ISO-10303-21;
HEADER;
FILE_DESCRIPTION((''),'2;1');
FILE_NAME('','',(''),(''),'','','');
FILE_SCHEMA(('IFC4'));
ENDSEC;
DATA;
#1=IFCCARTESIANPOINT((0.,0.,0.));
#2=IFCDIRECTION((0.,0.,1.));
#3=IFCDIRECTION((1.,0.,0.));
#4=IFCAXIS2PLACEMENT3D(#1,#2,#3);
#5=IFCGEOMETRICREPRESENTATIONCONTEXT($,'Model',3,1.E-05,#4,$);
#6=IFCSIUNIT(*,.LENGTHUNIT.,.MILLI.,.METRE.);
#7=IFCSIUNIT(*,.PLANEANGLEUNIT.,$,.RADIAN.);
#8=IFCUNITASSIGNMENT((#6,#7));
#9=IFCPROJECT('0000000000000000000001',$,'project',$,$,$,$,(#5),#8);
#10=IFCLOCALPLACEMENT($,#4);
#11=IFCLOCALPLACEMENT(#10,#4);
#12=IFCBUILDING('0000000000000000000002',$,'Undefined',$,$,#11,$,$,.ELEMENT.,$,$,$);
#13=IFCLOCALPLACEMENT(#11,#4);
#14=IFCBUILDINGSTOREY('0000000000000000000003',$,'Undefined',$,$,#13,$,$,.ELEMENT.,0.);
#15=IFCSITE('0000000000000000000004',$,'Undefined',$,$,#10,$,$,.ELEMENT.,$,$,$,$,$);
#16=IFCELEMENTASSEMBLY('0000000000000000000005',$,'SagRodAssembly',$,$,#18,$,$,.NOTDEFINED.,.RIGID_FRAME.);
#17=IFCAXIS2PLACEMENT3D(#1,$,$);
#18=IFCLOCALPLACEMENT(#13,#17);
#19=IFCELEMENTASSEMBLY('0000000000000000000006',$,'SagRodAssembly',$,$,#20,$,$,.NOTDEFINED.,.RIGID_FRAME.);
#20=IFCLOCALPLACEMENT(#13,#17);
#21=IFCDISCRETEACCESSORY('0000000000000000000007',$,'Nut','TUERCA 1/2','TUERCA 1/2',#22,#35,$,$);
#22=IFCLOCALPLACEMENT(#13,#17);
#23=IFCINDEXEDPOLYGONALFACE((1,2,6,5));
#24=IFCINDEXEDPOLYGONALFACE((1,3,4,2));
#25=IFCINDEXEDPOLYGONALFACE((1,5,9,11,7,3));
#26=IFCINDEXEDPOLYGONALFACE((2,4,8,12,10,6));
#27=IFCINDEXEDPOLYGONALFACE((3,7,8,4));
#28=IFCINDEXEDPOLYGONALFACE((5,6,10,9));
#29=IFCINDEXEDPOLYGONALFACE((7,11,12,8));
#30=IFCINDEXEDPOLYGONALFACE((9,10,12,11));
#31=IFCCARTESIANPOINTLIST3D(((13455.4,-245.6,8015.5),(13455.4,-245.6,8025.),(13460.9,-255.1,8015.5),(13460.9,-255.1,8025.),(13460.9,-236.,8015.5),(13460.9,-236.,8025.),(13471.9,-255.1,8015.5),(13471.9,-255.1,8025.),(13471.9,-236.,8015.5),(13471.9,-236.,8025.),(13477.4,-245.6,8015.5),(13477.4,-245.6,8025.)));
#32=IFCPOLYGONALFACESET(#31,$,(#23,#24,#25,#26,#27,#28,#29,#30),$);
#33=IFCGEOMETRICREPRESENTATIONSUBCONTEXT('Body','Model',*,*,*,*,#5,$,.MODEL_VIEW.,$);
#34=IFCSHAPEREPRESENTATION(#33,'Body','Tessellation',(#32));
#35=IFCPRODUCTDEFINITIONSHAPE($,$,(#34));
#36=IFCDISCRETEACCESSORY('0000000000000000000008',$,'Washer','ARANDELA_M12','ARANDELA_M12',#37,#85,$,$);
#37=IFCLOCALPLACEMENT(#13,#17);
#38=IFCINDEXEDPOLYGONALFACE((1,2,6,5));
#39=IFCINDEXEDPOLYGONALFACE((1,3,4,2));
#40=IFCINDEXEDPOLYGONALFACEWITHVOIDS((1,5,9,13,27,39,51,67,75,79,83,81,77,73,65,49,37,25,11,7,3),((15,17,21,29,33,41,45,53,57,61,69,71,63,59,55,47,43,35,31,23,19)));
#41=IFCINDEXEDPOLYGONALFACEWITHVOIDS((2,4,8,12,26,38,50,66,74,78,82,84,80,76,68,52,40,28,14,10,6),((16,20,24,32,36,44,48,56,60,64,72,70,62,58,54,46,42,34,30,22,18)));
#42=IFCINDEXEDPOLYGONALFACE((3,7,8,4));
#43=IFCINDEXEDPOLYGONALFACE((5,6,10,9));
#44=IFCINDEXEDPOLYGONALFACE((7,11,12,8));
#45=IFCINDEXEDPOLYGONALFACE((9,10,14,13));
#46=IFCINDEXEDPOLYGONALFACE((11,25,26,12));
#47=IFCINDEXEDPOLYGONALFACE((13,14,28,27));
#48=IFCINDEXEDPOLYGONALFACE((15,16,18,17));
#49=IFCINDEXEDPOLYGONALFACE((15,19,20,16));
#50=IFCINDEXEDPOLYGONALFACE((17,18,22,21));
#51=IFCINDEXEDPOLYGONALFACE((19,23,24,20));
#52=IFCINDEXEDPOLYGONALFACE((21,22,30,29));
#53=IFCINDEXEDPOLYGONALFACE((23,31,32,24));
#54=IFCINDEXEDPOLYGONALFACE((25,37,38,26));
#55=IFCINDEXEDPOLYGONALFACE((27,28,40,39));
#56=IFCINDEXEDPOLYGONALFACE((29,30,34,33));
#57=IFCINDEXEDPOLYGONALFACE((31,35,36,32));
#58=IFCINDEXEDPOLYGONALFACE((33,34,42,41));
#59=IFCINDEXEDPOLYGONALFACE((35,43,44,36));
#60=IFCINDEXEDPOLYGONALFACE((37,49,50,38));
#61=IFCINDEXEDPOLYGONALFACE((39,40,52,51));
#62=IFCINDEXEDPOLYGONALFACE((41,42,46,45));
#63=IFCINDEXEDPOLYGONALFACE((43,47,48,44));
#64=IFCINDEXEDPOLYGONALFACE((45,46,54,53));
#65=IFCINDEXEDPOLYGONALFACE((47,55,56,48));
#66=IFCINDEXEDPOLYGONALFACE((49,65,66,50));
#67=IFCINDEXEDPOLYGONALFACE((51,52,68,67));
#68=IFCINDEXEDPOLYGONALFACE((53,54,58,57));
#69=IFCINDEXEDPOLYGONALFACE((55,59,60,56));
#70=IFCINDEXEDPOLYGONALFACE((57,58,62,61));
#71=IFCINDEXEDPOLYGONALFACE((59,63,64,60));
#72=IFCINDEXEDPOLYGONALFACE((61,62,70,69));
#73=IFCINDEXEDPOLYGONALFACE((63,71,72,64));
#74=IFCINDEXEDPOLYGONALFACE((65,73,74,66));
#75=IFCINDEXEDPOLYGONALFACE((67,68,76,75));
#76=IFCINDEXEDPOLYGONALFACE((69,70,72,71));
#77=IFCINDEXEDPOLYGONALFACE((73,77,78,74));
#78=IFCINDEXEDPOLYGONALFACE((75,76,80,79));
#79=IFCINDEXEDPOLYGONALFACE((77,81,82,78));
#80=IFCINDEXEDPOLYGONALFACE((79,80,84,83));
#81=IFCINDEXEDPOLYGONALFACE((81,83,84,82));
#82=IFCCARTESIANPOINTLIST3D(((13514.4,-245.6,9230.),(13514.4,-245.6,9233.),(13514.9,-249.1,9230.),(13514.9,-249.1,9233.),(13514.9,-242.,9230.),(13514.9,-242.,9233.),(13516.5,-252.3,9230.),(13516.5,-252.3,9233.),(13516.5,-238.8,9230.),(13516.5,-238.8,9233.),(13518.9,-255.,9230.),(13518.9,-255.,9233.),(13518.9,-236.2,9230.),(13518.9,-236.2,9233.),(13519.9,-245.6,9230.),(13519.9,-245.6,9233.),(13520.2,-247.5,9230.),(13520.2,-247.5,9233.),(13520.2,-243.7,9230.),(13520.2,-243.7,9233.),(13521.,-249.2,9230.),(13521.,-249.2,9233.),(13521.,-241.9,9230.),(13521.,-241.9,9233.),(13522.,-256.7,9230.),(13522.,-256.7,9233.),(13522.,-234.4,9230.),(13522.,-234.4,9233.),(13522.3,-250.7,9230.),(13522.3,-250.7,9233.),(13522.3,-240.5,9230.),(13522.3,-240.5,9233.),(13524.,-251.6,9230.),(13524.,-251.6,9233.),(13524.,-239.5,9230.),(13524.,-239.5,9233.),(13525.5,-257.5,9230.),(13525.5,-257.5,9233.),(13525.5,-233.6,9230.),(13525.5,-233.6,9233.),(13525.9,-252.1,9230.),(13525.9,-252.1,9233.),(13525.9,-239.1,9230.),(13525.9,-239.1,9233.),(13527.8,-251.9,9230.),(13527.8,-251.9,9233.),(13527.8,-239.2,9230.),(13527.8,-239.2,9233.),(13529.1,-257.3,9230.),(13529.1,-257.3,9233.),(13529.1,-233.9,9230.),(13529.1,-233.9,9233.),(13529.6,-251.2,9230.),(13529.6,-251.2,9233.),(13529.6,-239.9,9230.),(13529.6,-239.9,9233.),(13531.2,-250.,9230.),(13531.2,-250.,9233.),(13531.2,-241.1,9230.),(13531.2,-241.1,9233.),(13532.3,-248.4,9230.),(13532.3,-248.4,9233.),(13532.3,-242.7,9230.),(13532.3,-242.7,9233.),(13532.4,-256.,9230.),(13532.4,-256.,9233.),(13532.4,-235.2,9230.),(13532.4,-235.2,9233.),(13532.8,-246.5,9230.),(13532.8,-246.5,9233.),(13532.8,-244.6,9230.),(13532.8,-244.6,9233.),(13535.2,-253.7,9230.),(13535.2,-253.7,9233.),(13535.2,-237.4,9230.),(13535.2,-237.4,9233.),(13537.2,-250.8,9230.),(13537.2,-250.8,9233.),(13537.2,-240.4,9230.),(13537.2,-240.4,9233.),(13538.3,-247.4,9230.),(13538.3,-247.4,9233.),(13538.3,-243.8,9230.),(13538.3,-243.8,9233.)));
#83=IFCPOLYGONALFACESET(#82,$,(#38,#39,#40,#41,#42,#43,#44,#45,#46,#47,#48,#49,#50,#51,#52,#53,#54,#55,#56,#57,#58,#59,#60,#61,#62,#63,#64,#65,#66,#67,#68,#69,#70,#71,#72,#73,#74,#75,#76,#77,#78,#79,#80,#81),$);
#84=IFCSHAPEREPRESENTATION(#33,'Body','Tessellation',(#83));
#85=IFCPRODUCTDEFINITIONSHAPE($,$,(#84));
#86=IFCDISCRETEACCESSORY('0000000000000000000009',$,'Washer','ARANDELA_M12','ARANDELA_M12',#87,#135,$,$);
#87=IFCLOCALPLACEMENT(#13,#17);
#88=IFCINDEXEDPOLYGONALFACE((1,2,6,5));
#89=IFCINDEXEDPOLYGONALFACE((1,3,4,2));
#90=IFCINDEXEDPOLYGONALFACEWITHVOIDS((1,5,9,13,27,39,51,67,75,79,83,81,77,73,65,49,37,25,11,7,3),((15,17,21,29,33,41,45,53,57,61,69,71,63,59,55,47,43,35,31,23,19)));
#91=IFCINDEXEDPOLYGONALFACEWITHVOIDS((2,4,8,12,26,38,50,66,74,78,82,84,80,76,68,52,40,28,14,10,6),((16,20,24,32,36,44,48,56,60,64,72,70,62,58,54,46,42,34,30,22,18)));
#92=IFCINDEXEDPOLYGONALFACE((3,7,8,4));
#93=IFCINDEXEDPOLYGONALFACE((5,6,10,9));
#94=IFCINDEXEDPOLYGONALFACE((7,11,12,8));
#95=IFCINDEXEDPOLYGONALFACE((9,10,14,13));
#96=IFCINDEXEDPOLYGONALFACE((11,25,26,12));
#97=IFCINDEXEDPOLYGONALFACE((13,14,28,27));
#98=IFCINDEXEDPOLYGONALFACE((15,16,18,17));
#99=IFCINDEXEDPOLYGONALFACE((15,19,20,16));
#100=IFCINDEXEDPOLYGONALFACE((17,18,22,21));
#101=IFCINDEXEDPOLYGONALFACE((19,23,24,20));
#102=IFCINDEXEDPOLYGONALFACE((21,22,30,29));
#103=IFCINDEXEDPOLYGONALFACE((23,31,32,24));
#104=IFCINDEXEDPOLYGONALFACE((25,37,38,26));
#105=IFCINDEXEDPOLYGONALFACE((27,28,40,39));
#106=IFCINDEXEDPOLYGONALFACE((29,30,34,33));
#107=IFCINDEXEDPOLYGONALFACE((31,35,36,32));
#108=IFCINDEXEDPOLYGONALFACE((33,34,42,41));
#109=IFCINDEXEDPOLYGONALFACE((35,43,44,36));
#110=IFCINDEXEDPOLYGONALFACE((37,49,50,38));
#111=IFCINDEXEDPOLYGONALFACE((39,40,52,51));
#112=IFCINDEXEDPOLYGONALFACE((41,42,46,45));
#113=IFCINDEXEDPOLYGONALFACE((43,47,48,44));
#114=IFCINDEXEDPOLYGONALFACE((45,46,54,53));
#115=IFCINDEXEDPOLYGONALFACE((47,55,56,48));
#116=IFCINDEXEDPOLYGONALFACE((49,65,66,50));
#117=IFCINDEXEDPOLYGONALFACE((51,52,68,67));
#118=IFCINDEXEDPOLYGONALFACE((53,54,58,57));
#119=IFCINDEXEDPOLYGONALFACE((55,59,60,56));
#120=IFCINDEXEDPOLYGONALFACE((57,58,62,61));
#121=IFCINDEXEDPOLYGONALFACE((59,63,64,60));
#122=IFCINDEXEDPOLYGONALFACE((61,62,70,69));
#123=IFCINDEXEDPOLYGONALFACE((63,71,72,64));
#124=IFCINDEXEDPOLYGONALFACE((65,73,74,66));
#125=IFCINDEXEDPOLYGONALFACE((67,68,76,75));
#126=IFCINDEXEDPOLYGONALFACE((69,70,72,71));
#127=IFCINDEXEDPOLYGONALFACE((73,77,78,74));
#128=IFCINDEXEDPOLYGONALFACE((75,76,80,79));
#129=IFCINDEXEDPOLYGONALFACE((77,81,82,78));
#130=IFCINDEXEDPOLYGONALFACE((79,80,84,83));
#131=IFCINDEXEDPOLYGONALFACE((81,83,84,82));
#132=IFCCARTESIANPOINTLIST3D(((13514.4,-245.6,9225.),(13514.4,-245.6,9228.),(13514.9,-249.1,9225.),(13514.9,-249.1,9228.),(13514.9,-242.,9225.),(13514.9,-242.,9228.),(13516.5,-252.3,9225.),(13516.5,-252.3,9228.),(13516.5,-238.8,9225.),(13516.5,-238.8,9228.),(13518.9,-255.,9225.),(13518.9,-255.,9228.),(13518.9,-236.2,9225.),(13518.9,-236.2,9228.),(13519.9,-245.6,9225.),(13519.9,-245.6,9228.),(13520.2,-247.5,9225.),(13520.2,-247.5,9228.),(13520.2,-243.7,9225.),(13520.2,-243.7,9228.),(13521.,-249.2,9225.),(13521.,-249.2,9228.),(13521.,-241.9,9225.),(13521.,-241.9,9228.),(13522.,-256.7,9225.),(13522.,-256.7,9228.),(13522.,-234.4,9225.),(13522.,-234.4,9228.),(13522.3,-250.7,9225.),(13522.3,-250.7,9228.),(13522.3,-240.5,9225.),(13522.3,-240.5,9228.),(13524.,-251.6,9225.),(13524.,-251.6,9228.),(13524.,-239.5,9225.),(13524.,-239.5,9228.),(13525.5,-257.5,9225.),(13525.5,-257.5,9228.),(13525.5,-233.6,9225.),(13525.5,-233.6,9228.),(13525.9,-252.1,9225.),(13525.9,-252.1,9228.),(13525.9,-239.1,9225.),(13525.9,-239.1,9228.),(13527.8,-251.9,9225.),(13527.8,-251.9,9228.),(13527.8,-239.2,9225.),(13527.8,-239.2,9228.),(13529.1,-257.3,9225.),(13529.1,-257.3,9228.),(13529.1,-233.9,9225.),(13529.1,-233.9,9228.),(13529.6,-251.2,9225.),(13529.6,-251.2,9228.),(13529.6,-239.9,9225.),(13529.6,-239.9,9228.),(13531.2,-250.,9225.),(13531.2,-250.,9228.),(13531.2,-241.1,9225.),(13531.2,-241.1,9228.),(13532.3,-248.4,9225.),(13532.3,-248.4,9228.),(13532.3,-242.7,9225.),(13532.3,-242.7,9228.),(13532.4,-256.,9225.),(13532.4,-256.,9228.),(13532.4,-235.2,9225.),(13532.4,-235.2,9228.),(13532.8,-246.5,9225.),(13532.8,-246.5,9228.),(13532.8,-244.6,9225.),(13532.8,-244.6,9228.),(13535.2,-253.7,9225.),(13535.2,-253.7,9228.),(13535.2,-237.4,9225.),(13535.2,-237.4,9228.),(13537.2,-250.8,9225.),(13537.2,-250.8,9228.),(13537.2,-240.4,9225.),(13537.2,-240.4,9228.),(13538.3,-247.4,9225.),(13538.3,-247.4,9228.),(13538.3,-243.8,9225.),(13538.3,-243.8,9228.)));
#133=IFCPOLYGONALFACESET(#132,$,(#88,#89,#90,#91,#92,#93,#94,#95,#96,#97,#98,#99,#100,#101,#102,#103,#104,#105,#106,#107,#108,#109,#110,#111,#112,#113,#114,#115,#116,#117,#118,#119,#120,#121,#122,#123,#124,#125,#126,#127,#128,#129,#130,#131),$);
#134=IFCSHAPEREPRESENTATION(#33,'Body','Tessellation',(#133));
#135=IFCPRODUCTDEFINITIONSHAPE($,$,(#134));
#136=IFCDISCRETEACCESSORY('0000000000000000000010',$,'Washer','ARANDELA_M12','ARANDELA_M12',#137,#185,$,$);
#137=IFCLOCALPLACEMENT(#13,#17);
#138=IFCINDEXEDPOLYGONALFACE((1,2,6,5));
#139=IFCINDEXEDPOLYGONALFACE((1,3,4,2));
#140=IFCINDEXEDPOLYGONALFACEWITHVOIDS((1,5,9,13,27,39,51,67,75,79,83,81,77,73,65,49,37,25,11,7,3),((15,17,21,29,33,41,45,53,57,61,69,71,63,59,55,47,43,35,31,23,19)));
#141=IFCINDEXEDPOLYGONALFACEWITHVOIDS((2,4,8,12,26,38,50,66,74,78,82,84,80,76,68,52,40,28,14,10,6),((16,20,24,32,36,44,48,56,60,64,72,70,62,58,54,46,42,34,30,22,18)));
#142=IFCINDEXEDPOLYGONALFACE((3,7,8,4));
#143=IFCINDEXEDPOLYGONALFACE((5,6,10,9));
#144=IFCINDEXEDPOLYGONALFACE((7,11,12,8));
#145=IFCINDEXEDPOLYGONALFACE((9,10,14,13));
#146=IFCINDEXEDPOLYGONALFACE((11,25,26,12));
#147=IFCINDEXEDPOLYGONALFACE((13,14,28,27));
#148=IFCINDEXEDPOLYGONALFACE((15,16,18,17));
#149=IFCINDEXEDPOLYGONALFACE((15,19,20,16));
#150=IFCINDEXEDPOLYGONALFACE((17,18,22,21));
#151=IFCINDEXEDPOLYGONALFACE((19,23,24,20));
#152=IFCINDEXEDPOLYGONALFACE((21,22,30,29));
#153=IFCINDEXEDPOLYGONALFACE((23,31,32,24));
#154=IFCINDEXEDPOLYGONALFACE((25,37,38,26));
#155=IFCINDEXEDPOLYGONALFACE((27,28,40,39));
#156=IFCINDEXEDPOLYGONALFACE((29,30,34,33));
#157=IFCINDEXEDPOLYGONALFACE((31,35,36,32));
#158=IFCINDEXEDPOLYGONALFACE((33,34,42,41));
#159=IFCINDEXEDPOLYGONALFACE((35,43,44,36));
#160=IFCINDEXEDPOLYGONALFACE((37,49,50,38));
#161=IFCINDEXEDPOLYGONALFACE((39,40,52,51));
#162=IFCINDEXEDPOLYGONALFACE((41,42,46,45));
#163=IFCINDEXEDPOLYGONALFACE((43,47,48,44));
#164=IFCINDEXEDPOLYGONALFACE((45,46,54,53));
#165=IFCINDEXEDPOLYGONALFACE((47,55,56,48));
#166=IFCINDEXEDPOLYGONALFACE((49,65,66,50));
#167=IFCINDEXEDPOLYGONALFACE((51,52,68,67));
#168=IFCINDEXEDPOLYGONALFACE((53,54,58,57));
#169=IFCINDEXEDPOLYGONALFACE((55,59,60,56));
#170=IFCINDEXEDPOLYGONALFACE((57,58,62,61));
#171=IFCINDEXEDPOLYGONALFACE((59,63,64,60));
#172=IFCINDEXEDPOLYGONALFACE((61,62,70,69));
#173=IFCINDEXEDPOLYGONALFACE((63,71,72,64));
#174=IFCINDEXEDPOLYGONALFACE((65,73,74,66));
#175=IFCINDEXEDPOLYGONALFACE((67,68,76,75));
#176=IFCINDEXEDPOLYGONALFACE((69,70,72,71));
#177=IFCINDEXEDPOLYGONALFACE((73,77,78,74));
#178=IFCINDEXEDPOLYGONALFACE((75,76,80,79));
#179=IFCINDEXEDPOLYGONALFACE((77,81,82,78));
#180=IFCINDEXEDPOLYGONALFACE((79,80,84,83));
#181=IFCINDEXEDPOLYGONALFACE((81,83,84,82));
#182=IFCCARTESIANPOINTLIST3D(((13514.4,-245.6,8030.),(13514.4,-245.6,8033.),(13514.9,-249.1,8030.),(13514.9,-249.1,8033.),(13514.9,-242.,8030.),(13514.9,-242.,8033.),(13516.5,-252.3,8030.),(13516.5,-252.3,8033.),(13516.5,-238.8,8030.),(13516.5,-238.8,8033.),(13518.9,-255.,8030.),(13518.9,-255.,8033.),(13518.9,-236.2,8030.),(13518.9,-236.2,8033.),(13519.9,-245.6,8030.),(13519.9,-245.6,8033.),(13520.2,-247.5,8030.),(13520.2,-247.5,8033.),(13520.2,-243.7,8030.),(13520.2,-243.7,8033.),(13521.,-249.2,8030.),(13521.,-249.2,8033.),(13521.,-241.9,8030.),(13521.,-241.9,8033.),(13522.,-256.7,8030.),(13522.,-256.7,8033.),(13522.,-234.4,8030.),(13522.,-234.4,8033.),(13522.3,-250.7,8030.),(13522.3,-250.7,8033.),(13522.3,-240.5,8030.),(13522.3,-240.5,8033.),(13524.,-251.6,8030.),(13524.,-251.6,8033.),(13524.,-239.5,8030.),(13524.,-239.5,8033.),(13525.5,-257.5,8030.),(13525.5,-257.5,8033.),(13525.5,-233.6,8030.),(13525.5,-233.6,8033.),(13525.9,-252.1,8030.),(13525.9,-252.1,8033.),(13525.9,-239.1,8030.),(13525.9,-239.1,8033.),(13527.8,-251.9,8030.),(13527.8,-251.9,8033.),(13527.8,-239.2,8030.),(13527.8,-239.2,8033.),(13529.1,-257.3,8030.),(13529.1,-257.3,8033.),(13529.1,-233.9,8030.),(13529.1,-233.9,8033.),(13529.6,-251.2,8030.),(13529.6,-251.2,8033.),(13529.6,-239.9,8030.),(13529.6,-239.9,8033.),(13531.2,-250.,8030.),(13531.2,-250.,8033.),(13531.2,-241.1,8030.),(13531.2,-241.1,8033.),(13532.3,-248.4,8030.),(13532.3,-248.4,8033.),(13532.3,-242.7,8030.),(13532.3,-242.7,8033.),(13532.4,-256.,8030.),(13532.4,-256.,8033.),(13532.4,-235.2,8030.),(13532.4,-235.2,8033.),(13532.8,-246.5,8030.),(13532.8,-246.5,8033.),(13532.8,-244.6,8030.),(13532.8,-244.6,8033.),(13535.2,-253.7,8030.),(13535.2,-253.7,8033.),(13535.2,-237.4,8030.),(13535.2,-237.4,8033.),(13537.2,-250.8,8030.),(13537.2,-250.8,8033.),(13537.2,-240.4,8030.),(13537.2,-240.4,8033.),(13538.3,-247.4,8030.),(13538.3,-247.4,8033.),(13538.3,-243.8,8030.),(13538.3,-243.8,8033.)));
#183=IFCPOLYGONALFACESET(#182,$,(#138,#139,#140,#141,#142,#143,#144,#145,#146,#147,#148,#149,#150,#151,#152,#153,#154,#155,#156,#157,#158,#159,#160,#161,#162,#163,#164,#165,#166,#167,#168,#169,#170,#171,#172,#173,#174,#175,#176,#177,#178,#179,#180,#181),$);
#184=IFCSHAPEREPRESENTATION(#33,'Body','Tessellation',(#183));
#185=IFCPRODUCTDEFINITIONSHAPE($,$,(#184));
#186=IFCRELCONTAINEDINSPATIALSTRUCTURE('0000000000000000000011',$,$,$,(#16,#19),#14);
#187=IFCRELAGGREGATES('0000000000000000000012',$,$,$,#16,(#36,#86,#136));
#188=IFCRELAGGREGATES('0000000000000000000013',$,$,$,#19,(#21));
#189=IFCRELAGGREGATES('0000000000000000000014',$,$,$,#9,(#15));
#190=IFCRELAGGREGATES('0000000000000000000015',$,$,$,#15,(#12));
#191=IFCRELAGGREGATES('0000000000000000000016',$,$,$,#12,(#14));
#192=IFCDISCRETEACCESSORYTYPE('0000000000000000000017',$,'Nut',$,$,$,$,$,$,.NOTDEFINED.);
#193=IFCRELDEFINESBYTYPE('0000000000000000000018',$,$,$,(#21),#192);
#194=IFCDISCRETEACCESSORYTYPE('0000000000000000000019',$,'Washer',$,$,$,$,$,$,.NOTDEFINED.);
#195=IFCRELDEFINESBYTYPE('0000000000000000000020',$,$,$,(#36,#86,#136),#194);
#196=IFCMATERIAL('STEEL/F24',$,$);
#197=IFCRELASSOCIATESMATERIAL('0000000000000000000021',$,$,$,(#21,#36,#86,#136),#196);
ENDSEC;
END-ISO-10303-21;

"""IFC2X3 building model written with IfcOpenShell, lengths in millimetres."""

from ifc_helpers import new_model, si_unit, frame, origin_with_axes, origin_2d_with_axis, place, context, subcontext, project, spatial, polyline, hollow_circle, outline, extrude, material, type_object, element, aggregate, save


model = new_model("IFC2X3")

# Units and contexts
model_context = context("Model", 3, precision=1e-05, world=origin_with_axes())
body_context = subcontext(model_context, "Body", "Model", "MODEL_VIEW")
ifc_project = project(units=[si_unit("LENGTHUNIT", "METRE", prefix="MILLI"), si_unit("PLANEANGLEUNIT", "RADIAN")], contexts=[model_context])

# Site, building, storey
site_placement = place(None, origin_with_axes())
site = spatial("IfcSite", under=ifc_project, at=site_placement, Name="Undefined", CompositionType="ELEMENT")
building_placement = place(site_placement, origin_with_axes())
building = spatial("IfcBuilding", under=site, at=building_placement, Name="Undefined", CompositionType="ELEMENT")
storey_placement = place(building_placement, origin_with_axes())
storey = spatial("IfcBuildingStorey", under=building, at=storey_placement, Name="Undefined", CompositionType="ELEMENT", Elevation=0.0)

# Shared definitions
ifc_material_1 = material(Name="STEEL/F24")

# Shared definitions
discrete_accessory_type_1 = type_object("IfcDiscreteAccessoryType", Name="Nut")

# Element assemblies, discrete accessory
assembly_1_placement = place(storey_placement, origin_with_axes())
assembly_1 = element("IfcElementAssembly", 1, at=assembly_1_placement, inside=storey, Name="SagRodAssembly", AssemblyPlace="NOTDEFINED", PredefinedType="RIGID_FRAME")
assembly_2_placement = place(storey_placement, origin_with_axes())
assembly_2 = element("IfcElementAssembly", 2, at=assembly_2_placement, inside=storey, Name="SagRodAssembly", AssemblyPlace="NOTDEFINED", PredefinedType="RIGID_FRAME")
discrete_accessory_1_placement = place(assembly_2_placement, frame((13466.4, -245.6, 8015.5), z_axis=(0.0, 0.0, 1.0), x_axis=(0.0, 1.0, 0.0)))
discrete_accessory_1 = element("IfcDiscreteAccessory", 3, at=discrete_accessory_1_placement, type_object=discrete_accessory_type_1, material=ifc_material_1, Name="Nut", Description="TUERCA 1/2", ObjectType="TUERCA 1/2", context=body_context, shape_type="SweptSolid", body=[
    extrude(outline(polyline([(-5.5, 9.5), (5.5, 9.5), (11.0, 0.0), (5.5, -9.5), (-5.5, -9.5), (-11.0, 0.0), (-5.5, 9.5)])), frame((0.0, 0.0, 9.5), z_axis=(0.0, 0.0, -1.0), x_axis=(0.0, 1.0, 0.0)), (0.0, 0.0, 1.0), 9.5),
])

# Discrete accessories
discrete_accessory_type_2 = type_object("IfcDiscreteAccessoryType", Name="Washer")
discrete_accessory_2_placement = place(assembly_1_placement, frame((13526.4, -245.6, 9230.0), z_axis=(0.0, 0.0, 1.0), x_axis=(0.0, 1.0, 0.0)))
discrete_accessory_2 = element("IfcDiscreteAccessory", 4, at=discrete_accessory_2_placement, type_object=discrete_accessory_type_2, material=ifc_material_1, Name="Washer", Description="ARANDELA_M12", ObjectType="ARANDELA_M12", context=body_context, shape_type="SweptSolid", body=[
    extrude(hollow_circle(Radius=12.0, WallThickness=5.5, at=origin_2d_with_axis()), frame((0.0, 0.0, 3.0), z_axis=(0.0, 0.0, -1.0), x_axis=(0.0, 1.0, 0.0)), (0.0, 0.0, 1.0), 3.0),
])
discrete_accessory_3_placement = place(assembly_1_placement, frame((13526.4, -245.6, 9225.0), z_axis=(0.0, 0.0, 1.0), x_axis=(0.0, 1.0, 0.0)))
discrete_accessory_3 = element("IfcDiscreteAccessory", 5, at=discrete_accessory_3_placement, type_object=discrete_accessory_type_2, material=ifc_material_1, Name="Washer", Description="ARANDELA_M12", ObjectType="ARANDELA_M12", context=body_context, shape_type="SweptSolid", body=[
    extrude(hollow_circle(Radius=12.0, WallThickness=5.5, at=origin_2d_with_axis()), frame((0.0, 0.0, 3.0), z_axis=(0.0, 0.0, -1.0), x_axis=(0.0, 1.0, 0.0)), (0.0, 0.0, 1.0), 3.0),
])
discrete_accessory_4_placement = place(assembly_1_placement, frame((13526.4, -245.6, 8030.0), z_axis=(0.0, 0.0, 1.0), x_axis=(0.0, 1.0, 0.0)))
discrete_accessory_4 = element("IfcDiscreteAccessory", 6, at=discrete_accessory_4_placement, type_object=discrete_accessory_type_2, material=ifc_material_1, Name="Washer", Description="ARANDELA_M12", ObjectType="ARANDELA_M12", context=body_context, shape_type="SweptSolid", body=[
    extrude(hollow_circle(Radius=12.0, WallThickness=5.5, at=origin_2d_with_axis()), frame((0.0, 0.0, 3.0), z_axis=(0.0, 0.0, -1.0), x_axis=(0.0, 1.0, 0.0)), (0.0, 0.0, 1.0), 3.0),
])
aggregate(assembly_1, [discrete_accessory_2, discrete_accessory_3, discrete_accessory_4])
aggregate(assembly_2, [discrete_accessory_1])

save(model, "model.ifc")
